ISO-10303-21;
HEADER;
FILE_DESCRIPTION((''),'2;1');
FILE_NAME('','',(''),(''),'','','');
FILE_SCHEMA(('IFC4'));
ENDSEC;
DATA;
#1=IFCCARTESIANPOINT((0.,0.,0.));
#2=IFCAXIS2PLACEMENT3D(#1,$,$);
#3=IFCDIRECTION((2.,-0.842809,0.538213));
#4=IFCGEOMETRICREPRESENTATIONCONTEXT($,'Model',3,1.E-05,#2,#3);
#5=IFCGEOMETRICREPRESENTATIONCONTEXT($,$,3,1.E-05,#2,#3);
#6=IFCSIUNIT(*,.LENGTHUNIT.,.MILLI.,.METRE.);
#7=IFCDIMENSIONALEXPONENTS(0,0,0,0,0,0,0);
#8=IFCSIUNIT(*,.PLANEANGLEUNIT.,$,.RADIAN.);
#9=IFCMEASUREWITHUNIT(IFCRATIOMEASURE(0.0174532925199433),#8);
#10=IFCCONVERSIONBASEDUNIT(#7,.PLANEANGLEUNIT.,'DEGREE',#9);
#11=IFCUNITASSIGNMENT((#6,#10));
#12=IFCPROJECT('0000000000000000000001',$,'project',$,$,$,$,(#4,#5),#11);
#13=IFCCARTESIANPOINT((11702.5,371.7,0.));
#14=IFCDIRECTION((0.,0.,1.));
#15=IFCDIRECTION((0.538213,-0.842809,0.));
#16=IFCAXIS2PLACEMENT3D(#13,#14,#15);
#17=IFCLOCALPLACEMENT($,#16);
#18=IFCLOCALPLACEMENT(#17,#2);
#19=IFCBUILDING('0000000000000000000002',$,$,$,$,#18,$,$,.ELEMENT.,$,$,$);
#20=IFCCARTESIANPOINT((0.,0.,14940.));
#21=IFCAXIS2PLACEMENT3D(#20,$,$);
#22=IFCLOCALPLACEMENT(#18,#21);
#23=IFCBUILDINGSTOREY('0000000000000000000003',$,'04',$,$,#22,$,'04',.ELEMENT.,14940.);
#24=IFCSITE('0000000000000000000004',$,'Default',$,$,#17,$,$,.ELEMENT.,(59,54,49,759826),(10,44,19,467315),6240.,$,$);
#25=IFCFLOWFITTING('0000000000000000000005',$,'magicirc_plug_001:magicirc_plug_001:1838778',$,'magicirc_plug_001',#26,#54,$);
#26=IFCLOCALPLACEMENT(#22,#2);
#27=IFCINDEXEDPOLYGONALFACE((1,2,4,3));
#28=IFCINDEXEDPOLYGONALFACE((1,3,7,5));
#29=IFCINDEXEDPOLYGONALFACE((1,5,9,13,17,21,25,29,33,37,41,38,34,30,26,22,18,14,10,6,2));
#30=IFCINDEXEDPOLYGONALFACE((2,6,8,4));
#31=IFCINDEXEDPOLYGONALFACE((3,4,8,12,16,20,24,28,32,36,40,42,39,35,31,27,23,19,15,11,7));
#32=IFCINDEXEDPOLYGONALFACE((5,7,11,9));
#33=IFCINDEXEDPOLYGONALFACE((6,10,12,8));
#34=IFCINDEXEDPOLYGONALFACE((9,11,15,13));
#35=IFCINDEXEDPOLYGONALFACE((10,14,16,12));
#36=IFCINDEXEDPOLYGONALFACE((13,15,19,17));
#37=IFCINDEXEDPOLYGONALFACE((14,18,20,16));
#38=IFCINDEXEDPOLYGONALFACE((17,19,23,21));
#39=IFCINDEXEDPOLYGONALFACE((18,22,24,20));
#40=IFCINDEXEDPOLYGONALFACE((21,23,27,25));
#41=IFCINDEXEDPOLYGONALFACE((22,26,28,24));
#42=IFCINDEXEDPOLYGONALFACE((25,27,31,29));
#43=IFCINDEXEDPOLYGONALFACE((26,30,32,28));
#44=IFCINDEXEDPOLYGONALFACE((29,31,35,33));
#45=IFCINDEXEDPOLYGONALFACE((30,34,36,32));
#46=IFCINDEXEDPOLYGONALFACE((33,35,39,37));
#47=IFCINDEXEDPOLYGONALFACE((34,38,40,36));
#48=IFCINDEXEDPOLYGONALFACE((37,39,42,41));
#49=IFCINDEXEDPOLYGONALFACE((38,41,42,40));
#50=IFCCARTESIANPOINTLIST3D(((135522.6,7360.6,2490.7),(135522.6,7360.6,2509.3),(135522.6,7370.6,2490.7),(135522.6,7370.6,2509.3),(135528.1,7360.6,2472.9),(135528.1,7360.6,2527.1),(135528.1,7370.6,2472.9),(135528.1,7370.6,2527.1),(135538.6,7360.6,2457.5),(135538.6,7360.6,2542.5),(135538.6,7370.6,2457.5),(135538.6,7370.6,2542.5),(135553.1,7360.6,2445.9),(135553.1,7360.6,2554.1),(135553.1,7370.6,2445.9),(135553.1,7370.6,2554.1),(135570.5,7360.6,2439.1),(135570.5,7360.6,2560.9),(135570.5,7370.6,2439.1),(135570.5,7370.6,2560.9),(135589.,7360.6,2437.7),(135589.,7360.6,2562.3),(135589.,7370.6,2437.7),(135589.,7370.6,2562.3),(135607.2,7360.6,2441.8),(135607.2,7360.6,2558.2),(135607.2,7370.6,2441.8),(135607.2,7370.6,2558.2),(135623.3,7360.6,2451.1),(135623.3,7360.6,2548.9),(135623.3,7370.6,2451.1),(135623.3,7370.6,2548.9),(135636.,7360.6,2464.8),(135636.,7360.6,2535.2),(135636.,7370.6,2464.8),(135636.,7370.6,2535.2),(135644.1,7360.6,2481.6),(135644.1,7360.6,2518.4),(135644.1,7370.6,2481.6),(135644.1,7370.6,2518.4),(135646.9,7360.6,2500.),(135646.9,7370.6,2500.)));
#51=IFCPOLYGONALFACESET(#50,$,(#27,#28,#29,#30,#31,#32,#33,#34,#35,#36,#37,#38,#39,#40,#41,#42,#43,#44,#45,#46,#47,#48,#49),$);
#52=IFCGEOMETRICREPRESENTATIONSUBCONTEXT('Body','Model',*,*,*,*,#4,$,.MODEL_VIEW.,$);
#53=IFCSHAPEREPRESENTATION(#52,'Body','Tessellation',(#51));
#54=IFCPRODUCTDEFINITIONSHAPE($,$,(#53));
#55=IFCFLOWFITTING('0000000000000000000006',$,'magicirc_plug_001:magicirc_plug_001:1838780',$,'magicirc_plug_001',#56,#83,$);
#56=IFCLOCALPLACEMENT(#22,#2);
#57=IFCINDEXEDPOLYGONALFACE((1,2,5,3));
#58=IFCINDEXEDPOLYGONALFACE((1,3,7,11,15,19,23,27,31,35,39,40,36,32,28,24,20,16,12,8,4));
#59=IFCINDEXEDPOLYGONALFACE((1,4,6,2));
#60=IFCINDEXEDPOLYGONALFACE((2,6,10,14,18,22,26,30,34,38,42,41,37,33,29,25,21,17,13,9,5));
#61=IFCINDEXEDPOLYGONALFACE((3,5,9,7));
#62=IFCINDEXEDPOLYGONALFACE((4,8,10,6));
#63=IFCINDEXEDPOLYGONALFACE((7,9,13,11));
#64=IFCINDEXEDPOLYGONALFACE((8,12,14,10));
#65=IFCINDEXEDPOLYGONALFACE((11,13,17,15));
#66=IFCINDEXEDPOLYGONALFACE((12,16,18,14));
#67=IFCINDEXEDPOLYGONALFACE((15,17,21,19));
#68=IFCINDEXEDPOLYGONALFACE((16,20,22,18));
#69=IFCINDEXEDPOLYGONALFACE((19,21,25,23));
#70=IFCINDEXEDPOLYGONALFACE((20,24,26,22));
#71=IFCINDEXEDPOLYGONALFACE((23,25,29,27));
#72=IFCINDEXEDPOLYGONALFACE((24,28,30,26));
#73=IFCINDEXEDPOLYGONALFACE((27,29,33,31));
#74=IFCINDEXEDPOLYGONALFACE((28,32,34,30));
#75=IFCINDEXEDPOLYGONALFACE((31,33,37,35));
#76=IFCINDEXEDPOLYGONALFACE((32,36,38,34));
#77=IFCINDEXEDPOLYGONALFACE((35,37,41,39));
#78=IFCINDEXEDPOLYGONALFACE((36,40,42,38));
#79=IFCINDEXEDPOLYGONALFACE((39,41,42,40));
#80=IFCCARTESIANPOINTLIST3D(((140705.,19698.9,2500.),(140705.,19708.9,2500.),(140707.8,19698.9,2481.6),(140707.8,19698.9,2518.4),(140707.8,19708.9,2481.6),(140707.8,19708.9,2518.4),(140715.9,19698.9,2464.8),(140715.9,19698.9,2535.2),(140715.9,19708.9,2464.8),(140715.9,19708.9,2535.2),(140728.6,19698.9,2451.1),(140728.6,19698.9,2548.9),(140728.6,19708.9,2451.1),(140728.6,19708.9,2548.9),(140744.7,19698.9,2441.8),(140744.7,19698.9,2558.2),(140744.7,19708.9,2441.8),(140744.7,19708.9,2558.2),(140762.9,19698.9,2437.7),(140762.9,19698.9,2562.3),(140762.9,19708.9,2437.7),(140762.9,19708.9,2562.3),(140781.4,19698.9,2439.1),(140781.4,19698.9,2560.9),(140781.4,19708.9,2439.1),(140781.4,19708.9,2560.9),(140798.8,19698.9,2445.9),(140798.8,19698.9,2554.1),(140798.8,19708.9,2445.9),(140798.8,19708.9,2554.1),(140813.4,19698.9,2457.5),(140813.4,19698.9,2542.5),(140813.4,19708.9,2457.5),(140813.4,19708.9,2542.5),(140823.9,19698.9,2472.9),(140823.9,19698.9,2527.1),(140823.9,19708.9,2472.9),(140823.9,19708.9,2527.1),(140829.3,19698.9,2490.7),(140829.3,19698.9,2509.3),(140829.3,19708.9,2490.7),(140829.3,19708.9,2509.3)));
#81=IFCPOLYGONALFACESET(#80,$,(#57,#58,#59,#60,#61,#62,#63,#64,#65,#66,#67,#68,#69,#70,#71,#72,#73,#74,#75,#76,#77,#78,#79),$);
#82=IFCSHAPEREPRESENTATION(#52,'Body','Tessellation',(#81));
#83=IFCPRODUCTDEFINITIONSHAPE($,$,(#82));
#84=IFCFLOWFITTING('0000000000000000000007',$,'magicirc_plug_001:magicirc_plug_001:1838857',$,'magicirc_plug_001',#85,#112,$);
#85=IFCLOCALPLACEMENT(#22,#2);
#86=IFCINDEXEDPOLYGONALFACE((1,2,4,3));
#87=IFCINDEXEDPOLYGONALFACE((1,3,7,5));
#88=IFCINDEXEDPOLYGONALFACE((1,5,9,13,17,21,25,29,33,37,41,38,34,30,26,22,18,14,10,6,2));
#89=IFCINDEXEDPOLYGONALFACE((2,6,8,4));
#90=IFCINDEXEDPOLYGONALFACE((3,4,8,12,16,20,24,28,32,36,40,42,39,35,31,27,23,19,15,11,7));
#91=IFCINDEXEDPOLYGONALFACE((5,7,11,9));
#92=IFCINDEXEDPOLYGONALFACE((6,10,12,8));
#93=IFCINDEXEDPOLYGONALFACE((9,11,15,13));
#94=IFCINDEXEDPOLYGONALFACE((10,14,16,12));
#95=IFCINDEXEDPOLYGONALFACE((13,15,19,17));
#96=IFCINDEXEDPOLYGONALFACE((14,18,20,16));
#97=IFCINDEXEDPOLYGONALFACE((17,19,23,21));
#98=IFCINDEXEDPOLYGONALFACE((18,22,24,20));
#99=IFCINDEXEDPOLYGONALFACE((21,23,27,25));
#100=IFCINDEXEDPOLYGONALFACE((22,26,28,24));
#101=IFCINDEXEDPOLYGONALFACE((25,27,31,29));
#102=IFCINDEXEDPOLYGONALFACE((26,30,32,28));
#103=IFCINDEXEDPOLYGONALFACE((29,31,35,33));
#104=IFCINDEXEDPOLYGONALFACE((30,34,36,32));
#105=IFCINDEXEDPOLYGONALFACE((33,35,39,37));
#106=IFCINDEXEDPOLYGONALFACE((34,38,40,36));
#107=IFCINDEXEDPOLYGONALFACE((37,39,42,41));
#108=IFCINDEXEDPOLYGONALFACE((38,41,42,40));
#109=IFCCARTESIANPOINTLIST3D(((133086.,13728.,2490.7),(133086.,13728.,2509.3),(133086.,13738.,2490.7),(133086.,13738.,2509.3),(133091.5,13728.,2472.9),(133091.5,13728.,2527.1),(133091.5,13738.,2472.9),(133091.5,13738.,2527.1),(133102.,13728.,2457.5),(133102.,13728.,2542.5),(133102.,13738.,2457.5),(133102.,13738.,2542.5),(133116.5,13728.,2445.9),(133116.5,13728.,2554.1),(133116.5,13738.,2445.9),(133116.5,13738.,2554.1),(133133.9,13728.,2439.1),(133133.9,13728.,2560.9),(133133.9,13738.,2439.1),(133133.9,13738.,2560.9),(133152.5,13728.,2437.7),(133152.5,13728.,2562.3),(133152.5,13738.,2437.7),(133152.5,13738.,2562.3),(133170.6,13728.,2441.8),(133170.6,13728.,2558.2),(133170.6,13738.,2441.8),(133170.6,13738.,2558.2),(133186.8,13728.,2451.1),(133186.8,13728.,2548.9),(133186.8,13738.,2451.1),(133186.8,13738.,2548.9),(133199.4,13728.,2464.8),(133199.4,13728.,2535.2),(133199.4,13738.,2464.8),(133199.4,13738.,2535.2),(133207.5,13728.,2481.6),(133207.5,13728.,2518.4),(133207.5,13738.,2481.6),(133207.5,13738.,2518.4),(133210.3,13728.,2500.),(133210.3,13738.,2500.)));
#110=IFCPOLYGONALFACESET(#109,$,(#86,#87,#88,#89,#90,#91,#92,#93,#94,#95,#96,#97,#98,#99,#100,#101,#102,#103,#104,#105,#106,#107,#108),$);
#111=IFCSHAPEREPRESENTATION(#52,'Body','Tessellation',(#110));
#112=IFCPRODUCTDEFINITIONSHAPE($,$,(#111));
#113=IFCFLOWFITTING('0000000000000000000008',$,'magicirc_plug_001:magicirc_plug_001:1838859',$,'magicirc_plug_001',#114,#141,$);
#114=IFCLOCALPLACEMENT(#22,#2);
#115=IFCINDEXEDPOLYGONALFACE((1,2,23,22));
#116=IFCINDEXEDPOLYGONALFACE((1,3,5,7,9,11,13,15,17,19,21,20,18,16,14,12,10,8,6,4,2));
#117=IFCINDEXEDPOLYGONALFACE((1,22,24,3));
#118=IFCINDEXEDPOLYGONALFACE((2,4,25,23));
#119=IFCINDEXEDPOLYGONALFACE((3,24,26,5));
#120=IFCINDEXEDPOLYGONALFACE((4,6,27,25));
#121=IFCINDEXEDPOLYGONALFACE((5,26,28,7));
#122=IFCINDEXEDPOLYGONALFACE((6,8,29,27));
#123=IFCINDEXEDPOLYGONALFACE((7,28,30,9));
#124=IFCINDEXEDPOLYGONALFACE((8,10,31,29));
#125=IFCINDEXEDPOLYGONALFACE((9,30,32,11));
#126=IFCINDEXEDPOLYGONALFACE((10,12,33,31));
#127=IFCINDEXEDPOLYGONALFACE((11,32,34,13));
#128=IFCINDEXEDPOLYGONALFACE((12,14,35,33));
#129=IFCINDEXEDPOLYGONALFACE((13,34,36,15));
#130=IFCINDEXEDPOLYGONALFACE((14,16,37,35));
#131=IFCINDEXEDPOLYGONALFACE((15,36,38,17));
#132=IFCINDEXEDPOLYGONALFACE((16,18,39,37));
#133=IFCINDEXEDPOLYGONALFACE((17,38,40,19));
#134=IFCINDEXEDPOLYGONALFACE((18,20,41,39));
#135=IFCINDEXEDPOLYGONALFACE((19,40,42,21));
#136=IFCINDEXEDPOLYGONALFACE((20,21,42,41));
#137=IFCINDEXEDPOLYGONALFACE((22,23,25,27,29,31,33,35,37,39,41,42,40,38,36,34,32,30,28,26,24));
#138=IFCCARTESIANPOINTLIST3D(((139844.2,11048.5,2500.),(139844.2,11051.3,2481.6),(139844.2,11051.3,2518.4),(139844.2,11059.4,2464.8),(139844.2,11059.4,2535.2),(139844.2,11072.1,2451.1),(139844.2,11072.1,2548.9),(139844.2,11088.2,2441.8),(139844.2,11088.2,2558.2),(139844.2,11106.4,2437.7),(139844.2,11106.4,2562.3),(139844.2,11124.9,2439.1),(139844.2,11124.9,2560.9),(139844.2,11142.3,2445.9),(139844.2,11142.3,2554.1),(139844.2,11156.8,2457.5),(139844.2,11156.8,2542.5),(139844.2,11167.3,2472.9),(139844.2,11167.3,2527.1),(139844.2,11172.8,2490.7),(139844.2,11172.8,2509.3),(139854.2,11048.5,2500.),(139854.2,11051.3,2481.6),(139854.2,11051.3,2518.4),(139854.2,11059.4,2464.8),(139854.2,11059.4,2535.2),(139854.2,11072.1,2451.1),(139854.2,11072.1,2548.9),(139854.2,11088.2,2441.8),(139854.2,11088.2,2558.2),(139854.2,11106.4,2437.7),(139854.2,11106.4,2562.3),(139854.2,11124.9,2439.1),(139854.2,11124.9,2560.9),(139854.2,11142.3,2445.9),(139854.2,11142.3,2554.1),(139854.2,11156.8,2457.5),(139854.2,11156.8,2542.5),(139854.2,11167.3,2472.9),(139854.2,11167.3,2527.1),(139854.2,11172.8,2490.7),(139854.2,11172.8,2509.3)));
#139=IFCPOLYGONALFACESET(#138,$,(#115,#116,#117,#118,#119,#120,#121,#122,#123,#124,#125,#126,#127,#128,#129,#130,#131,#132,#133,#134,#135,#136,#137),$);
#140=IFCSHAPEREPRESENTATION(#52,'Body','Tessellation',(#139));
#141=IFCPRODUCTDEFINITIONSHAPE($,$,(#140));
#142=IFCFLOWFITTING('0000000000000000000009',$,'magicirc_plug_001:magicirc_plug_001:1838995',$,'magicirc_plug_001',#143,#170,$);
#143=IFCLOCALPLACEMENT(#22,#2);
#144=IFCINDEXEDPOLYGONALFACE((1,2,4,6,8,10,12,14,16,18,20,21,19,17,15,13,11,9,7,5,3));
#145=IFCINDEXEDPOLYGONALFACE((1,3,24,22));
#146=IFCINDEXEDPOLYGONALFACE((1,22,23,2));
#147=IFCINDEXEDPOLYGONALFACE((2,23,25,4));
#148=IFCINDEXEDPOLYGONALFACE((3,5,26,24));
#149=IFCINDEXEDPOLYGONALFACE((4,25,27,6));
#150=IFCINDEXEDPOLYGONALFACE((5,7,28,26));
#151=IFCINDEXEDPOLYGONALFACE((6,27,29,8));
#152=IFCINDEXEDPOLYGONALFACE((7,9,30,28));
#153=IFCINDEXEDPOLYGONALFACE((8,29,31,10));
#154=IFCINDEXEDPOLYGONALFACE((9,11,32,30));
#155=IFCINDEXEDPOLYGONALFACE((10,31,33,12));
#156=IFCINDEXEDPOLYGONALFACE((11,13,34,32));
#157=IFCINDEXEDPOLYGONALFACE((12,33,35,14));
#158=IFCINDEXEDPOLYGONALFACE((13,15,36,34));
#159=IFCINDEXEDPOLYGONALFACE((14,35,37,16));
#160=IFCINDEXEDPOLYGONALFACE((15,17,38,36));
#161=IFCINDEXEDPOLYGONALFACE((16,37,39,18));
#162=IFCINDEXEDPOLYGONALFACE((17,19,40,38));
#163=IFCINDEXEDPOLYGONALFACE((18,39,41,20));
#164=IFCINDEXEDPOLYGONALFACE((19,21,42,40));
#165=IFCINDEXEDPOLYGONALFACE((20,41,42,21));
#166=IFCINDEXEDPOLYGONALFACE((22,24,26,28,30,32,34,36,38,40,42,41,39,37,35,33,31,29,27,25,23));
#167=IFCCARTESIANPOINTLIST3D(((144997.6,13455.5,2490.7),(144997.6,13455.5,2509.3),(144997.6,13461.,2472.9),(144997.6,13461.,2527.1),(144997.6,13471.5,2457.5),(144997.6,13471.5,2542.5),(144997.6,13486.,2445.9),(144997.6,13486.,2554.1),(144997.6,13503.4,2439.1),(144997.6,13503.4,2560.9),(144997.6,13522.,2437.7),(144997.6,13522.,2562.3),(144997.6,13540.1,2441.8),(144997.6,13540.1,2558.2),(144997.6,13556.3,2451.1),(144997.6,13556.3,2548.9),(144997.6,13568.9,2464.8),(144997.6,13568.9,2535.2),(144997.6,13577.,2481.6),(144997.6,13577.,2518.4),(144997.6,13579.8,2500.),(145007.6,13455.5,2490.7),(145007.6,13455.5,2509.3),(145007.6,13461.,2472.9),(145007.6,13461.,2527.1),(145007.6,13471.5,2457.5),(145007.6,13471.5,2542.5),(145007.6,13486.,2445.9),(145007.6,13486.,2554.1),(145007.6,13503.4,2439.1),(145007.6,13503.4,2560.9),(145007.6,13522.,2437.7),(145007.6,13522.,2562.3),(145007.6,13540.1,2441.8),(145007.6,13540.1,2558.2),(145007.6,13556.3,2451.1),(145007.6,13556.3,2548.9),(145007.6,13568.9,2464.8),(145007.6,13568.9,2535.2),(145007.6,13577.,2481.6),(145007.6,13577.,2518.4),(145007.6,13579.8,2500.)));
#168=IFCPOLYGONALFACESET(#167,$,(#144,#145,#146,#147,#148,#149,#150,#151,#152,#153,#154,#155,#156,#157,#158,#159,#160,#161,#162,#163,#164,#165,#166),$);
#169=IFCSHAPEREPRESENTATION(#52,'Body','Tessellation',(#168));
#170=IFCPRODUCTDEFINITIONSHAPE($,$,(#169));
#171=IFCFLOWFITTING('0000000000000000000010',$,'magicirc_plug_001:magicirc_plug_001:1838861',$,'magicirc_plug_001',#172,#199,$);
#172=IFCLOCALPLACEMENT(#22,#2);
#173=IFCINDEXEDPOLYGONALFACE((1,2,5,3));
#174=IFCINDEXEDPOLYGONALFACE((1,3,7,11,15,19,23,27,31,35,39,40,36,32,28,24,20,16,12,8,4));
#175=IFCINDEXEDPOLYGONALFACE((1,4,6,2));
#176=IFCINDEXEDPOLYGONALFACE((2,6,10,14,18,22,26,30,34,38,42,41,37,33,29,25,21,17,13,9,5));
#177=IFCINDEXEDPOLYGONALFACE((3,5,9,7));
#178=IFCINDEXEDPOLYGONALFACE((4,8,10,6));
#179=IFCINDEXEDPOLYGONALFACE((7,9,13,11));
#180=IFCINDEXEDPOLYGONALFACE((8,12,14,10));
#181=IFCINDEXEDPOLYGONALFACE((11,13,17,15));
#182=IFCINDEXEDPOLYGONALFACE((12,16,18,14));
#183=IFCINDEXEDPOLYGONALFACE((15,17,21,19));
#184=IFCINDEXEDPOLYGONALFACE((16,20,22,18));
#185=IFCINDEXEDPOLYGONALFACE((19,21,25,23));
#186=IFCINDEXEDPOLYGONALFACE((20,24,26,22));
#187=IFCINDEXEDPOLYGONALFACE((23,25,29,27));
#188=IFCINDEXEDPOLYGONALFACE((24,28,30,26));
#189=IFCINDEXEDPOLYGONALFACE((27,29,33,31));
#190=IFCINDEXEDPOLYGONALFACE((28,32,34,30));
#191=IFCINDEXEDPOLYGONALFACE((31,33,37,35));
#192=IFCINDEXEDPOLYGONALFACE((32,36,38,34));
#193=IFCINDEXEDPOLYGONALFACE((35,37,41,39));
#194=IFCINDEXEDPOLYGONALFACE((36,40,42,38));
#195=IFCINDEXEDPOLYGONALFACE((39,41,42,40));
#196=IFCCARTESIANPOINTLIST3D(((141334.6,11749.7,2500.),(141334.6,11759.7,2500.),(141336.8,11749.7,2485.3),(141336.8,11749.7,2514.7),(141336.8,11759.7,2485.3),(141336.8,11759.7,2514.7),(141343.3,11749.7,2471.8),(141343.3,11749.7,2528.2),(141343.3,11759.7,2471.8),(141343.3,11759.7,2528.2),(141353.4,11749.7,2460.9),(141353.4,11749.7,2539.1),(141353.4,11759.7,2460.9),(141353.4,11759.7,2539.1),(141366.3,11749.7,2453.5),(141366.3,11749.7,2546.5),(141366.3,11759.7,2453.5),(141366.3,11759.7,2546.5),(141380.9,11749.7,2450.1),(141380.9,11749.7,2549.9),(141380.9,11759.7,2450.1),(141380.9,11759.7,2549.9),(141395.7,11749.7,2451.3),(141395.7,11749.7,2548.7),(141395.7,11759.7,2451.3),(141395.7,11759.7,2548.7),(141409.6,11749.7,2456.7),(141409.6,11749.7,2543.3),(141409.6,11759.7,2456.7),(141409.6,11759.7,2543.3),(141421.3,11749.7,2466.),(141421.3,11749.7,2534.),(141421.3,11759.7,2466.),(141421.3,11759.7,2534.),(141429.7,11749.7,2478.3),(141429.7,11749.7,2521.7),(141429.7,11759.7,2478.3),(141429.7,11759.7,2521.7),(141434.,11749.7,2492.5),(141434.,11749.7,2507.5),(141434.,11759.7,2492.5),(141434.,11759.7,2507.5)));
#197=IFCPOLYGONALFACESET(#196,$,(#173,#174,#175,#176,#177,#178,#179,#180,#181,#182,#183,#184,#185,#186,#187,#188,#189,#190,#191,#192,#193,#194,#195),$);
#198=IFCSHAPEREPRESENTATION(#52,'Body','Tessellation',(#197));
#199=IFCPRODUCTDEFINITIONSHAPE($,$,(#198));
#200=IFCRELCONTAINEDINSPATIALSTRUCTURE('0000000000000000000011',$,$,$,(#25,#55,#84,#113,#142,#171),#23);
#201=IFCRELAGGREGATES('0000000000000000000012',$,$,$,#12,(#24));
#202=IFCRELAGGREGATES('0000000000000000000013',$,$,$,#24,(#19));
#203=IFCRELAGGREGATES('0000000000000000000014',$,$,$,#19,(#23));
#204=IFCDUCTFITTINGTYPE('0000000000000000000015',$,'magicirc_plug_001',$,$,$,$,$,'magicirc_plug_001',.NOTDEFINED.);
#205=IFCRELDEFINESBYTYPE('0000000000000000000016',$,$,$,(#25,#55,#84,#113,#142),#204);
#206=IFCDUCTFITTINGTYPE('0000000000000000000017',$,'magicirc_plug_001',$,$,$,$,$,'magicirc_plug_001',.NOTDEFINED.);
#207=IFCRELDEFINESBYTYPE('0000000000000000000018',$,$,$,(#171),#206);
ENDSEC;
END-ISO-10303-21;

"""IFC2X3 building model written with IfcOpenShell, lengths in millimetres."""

from ifc_helpers import new_model, entity, si_unit, converted_unit, direction, frame, frame_2d, origin, place, context, subcontext, project, spatial, circle, extrude, source, transform, mapped, type_object, type_shapes, element, save


model = new_model("IFC2X3")

# Units and contexts
model_context = context("Model", 3, precision=1e-05, world=origin(), true_north=direction((2.0, -0.842809, 0.538213)))
context_of_model = context(None, 3, precision=1e-05, world=origin(), true_north=direction((2.0, -0.842809, 0.538213)))
body_context = subcontext(model_context, "Body", "Model", "MODEL_VIEW")
ifc_project = project(units=[si_unit("LENGTHUNIT", "METRE", prefix="MILLI"), converted_unit("PLANEANGLEUNIT", "DEGREE", entity("IfcRatioMeasure", 0.0174532925199433), si_unit("PLANEANGLEUNIT", "RADIAN"), dimensions=[0, 0, 0, 0, 0, 0, 0])], contexts=[model_context, context_of_model])

# Site, building, storey
site_placement = place(None, frame((11702.5, 371.7, 0.0), z_axis=(0.0, 0.0, 1.0), x_axis=(0.538213, -0.842809, 0.0)))
site = spatial("IfcSite", under=ifc_project, at=site_placement, Name="Default", CompositionType="ELEMENT", RefLatitude=(59, 54, 49, 759826), RefLongitude=(10, 44, 19, 467315), RefElevation=6240.0)
building_placement = place(site_placement, origin())
building = spatial("IfcBuilding", under=site, at=building_placement, CompositionType="ELEMENT")
storey_placement = place(building_placement, frame((0.0, 0.0, 14940.0)))
storey = spatial("IfcBuildingStorey", under=building, at=storey_placement, Name="04", LongName="04", CompositionType="ELEMENT", Elevation=14940.0)

# Flow fittings
duct_fitting_type_1 = type_object("IfcDuctFittingType", Name="magicirc_plug_001", ElementType="magicirc_plug_001", PredefinedType="NOTDEFINED")
shared_shape_1 = source(origin(), body_context, "Body", "SweptSolid", [
    extrude(circle(Radius=62.5, at=frame_2d((0.0, 0.0), x_axis=(1.0, 0.0))), frame((0.0, 0.0, 0.0), z_axis=(1.0, 0.0, 0.0), x_axis=(0.0, 1.0, 0.0)), (0.0, 0.0, 1.0), 10.0),
])
type_shapes(duct_fitting_type_1, [shared_shape_1])
for number, where, z_axis, x_axis, name in (
    (1, (135584.4, 7370.6, 2500.0), (0.0, 0.0, 1.0), (0.0, -1.0, 0.0), "magicirc_plug_001:magicirc_plug_001:1838778"),
    (2, (140767.5, 19698.9, 2500.0), (0.0, 0.0, 1.0), (0.0, 1.0, 0.0), "magicirc_plug_001:magicirc_plug_001:1838780"),
    (3, (133147.8, 13738.0, 2500.0), (0.0, 0.0, 1.0), (0.0, -1.0, 0.0), "magicirc_plug_001:magicirc_plug_001:1838857"),
    (4, (139854.2, 11111.0, 2500.0), (0.0, 0.0, 1.0), (-1.0, 0.0, 0.0), "magicirc_plug_001:magicirc_plug_001:1838859"),
):
    element("IfcFlowFitting", number, at=place(storey_placement, frame(where, z_axis=z_axis, x_axis=x_axis)), inside=storey, type_object=duct_fitting_type_1, Name=name, ObjectType="magicirc_plug_001", context=body_context, shape_type="MappedRepresentation", body=[
        mapped(shared_shape_1, transform((0.0, 0.0, 0.0), scale=1.0)),
    ])
flow_fitting_1_placement = place(storey_placement, frame((144997.6, 13517.3, 2500.0)))
element("IfcFlowFitting", 5, at=flow_fitting_1_placement, inside=storey, type_object=duct_fitting_type_1, Name="magicirc_plug_001:magicirc_plug_001:1838995", ObjectType="magicirc_plug_001", context=body_context, shape_type="MappedRepresentation", body=[
    mapped(shared_shape_1, transform((0.0, 0.0, 0.0), scale=1.0)),
])
duct_fitting_type_2 = type_object("IfcDuctFittingType", Name="magicirc_plug_001", ElementType="magicirc_plug_001", PredefinedType="NOTDEFINED")
shared_shape_2 = source(origin(), body_context, "Body", "SweptSolid", [
    extrude(circle(Radius=50.0, at=frame_2d((0.0, 0.0), x_axis=(1.0, 0.0))), frame((0.0, 0.0, 0.0), z_axis=(1.0, 0.0, 0.0), x_axis=(0.0, 1.0, 0.0)), (0.0, 0.0, 1.0), 10.0),
])
type_shapes(duct_fitting_type_2, [shared_shape_2])
flow_fitting_2_placement = place(storey_placement, frame((141384.6, 11749.7, 2500.0), z_axis=(0.0, 0.0, 1.0), x_axis=(0.0, 1.0, 0.0)))
element("IfcFlowFitting", 6, at=flow_fitting_2_placement, inside=storey, type_object=duct_fitting_type_2, Name="magicirc_plug_001:magicirc_plug_001:1838861", ObjectType="magicirc_plug_001", context=body_context, shape_type="MappedRepresentation", body=[
    mapped(shared_shape_2, transform((0.0, 0.0, 0.0), scale=1.0)),
])

save(model, "model.ifc")
